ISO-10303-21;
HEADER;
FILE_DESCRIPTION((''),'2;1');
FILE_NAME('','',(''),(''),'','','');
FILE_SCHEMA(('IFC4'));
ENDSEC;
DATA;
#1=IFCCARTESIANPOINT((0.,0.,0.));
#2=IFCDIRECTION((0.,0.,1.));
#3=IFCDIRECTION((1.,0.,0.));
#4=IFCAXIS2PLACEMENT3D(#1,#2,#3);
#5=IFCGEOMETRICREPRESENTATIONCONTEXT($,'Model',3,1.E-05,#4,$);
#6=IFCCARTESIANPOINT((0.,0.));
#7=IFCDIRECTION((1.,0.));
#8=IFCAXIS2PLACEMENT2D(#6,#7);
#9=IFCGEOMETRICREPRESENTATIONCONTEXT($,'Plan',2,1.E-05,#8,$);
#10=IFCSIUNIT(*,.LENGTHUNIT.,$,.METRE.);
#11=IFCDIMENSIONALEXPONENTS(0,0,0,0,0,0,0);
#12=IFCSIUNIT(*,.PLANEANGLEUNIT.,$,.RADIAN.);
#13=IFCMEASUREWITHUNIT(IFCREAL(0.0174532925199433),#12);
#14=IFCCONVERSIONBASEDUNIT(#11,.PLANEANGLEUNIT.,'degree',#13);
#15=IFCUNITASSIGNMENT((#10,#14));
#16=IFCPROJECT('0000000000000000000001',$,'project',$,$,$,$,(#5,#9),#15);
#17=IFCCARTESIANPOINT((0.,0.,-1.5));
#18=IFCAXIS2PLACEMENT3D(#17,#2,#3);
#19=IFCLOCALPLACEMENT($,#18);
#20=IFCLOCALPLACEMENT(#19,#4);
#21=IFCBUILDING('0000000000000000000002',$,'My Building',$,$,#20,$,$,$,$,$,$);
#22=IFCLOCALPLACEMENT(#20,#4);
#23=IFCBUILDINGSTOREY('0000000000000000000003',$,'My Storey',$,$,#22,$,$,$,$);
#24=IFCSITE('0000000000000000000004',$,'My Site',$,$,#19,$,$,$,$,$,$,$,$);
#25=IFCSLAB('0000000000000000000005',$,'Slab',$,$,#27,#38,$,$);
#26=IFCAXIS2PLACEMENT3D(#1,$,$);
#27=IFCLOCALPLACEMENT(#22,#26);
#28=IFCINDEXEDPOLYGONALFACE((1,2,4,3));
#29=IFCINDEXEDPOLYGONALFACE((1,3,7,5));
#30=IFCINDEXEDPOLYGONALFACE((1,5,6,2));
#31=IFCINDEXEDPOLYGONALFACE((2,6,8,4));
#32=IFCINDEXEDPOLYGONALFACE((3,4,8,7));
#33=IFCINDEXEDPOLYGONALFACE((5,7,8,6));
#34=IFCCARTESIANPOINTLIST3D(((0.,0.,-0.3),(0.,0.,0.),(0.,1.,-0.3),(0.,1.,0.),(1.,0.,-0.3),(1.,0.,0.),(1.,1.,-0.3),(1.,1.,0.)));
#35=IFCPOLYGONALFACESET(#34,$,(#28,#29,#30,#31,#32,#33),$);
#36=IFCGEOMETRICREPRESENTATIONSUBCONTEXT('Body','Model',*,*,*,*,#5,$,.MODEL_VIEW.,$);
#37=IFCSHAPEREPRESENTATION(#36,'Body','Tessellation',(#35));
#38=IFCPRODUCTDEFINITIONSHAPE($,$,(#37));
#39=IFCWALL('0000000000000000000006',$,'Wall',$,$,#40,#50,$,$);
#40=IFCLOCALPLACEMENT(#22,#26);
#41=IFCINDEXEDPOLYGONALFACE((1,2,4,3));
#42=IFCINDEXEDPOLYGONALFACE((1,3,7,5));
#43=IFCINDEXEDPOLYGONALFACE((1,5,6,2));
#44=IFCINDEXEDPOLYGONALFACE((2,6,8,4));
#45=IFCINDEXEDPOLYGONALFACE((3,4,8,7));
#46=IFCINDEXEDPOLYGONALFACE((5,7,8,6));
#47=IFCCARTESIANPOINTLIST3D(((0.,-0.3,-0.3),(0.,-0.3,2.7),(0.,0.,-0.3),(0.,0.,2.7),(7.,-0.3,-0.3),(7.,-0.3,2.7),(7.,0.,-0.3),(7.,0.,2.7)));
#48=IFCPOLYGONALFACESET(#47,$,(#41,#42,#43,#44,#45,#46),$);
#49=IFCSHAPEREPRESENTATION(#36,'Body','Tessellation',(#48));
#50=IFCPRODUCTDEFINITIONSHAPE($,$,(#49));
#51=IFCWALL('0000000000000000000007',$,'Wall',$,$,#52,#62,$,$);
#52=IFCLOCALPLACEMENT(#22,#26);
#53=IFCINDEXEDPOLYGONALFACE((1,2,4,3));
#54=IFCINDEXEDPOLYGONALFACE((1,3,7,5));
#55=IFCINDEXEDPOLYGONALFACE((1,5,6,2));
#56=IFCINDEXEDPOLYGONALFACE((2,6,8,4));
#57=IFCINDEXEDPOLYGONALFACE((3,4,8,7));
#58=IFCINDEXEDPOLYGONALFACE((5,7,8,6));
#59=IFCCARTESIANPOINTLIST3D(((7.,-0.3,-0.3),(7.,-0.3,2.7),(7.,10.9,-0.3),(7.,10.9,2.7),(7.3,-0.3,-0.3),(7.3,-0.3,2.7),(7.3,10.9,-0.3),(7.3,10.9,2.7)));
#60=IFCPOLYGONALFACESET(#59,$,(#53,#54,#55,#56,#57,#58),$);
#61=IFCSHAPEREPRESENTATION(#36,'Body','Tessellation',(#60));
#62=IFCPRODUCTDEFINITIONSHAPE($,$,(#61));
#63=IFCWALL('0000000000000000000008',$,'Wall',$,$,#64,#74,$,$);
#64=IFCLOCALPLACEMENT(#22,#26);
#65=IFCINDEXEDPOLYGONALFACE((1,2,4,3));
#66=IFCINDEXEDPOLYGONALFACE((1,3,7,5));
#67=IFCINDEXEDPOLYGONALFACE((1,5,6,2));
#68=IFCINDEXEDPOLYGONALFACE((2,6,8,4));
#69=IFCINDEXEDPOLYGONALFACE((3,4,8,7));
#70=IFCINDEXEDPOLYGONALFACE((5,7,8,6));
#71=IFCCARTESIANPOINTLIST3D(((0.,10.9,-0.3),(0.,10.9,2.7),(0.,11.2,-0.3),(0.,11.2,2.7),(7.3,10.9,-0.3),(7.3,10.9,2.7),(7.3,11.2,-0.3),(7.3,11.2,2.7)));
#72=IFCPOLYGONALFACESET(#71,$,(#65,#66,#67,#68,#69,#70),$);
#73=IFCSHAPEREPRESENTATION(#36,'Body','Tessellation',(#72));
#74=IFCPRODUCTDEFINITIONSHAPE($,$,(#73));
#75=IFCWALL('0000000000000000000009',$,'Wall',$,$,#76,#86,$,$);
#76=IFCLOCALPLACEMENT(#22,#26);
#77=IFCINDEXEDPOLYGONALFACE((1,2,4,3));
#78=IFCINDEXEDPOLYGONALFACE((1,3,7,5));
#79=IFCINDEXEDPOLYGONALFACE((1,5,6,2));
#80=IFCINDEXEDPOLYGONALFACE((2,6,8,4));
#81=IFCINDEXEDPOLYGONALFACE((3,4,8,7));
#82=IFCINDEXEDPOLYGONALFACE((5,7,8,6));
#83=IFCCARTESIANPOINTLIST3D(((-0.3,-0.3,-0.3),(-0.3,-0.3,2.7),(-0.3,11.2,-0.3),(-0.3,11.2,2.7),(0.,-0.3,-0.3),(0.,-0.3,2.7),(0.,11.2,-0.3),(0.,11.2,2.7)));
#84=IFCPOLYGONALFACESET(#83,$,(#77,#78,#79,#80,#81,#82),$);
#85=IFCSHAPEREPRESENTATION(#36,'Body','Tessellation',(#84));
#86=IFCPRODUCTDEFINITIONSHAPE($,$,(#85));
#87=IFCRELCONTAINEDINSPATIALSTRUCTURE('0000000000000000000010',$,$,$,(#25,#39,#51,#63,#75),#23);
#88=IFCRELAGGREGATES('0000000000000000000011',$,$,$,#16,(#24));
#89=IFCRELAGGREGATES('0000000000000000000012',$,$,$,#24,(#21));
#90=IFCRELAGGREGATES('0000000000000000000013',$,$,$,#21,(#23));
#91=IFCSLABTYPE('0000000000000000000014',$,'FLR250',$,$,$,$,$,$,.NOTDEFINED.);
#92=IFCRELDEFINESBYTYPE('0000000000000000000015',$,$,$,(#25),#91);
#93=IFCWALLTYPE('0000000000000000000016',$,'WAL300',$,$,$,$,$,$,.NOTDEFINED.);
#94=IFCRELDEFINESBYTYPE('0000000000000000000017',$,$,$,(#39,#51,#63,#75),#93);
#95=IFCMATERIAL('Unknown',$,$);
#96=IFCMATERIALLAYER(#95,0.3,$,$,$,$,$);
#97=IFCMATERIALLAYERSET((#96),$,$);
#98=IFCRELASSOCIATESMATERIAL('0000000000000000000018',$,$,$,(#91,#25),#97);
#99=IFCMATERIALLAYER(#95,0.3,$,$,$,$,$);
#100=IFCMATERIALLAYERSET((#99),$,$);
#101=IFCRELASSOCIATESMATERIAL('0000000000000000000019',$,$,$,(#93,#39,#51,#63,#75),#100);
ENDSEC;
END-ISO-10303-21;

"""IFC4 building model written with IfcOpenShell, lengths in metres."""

from ifc_helpers import new_model, entity, si_unit, converted_unit, frame, origin_with_axes, origin_2d_with_axis, place, context, subcontext, project, spatial, line, indexed_curve, outline, extrude, material, layer, layer_set, layer_usage, type_object, element, save


model = new_model("IFC4")

# Units and contexts
model_context = context("Model", 3, precision=1e-05, world=origin_with_axes())
plan_context = context("Plan", 2, precision=1e-05, world=origin_2d_with_axis())
body_context = subcontext(model_context, "Body", "Model", "MODEL_VIEW")
ifc_project = project(units=[si_unit("LENGTHUNIT", "METRE"), converted_unit("PLANEANGLEUNIT", "degree", entity("IfcReal", 0.0174532925199433), si_unit("PLANEANGLEUNIT", "RADIAN"), dimensions=[0, 0, 0, 0, 0, 0, 0])], contexts=[model_context, plan_context])

# Site, building, storey
site_placement = place(None, frame((0.0, 0.0, -1.5), z_axis=(0.0, 0.0, 1.0), x_axis=(1.0, 0.0, 0.0)))
site = spatial("IfcSite", under=ifc_project, at=site_placement, Name="My Site")
building_placement = place(site_placement, origin_with_axes())
building = spatial("IfcBuilding", under=site, at=building_placement, Name="My Building")
storey_placement = place(building_placement, origin_with_axes())
storey = spatial("IfcBuildingStorey", under=building, at=storey_placement, Name="My Storey")

# Slab
ifc_material = material(Name="Unknown")
ifc_layer_1 = layer(ifc_material, 0.3)
ifc_layer_set_1 = layer_set([ifc_layer_1])
ifc_layer_usage_1 = layer_usage(ifc_layer_set_1, "AXIS3", "POSITIVE", 0.0)
slab_type = type_object("IfcSlabType", Name="FLR250", PredefinedType="NOTDEFINED", material=ifc_layer_set_1)
slab_placement = place(storey_placement, frame((0.0, 0.0, -0.3), z_axis=(0.0, 0.0, 1.0), x_axis=(1.0, 0.0, 0.0)))
element("IfcSlab", 1, at=slab_placement, inside=storey, type_object=slab_type, material=ifc_layer_usage_1, Name="Slab", context=body_context, shape_type="SweptSolid", body=[
    extrude(outline(indexed_curve([(0.0, 0.0), (0.0, 1.0), (1.0, 1.0), (1.0, 0.0)], segments=[line(4, 1), line(1, 2), line(2, 3), line(3, 4)], self_intersect=False)), None, (0.0, 0.0, 1.0), 0.3),
])

# Walls
ifc_layer_2 = layer(ifc_material, 0.3)
ifc_layer_set_2 = layer_set([ifc_layer_2])
ifc_layer_usage_2 = layer_usage(ifc_layer_set_2, "AXIS2", "POSITIVE", 0.0)
wall_type = type_object("IfcWallType", Name="WAL300", PredefinedType="NOTDEFINED", material=ifc_layer_set_2)
wall_1_placement = place(storey_placement, frame((0.0, -0.3, -0.3), z_axis=(0.0, 0.0, 1.0), x_axis=(1.0, 0.0, 0.0)))
element("IfcWall", 2, at=wall_1_placement, inside=storey, type_object=wall_type, material=ifc_layer_usage_2, Name="Wall", context=body_context, shape_type="SweptSolid", body=[
    extrude(outline(indexed_curve([(0.0, 0.0), (0.0, 0.3), (7.0, 0.3), (7.0, 0.0), (0.0, 0.0)], self_intersect=False)), origin_with_axes(), (0.0, 0.0, 1.0), 3.0),
])
ifc_layer_usage_3 = layer_usage(ifc_layer_set_2, "AXIS2", "POSITIVE", 0.0)
wall_2_placement = place(storey_placement, frame((7.0, 10.9, -0.3), z_axis=(0.0, 0.0, 1.0), x_axis=(0.0, -1.0, 0.0)))
element("IfcWall", 3, at=wall_2_placement, inside=storey, type_object=wall_type, material=ifc_layer_usage_3, Name="Wall", context=body_context, shape_type="SweptSolid", body=[
    extrude(outline(indexed_curve([(0.0, 0.0), (0.0, 0.3), (11.2, 0.3), (11.2, 0.0), (0.0, 0.0)], self_intersect=False)), origin_with_axes(), (0.0, 0.0, 1.0), 3.0),
])
ifc_layer_usage_4 = layer_usage(ifc_layer_set_2, "AXIS2", "POSITIVE", 0.0)
wall_3_placement = place(storey_placement, frame((7.3, 11.2, -0.3), z_axis=(0.0, 0.0, 1.0), x_axis=(-1.0, 0.0, 0.0)))
element("IfcWall", 4, at=wall_3_placement, inside=storey, type_object=wall_type, material=ifc_layer_usage_4, Name="Wall", context=body_context, shape_type="SweptSolid", body=[
    extrude(outline(indexed_curve([(0.0, 0.0), (0.0, 0.3), (7.3, 0.3), (7.3, 0.0), (0.0, 0.0)], self_intersect=False)), origin_with_axes(), (0.0, 0.0, 1.0), 3.0),
])
ifc_layer_usage_5 = layer_usage(ifc_layer_set_2, "AXIS2", "POSITIVE", 0.0)
wall_4_placement = place(storey_placement, frame((-0.3, 11.2, -0.3), z_axis=(0.0, 0.0, 1.0), x_axis=(0.0, -1.0, 0.0)))
element("IfcWall", 5, at=wall_4_placement, inside=storey, type_object=wall_type, material=ifc_layer_usage_5, Name="Wall", context=body_context, shape_type="SweptSolid", body=[
    extrude(outline(indexed_curve([(0.0, 0.0), (0.0, 0.3), (11.5, 0.3), (11.5, 0.0), (0.0, 0.0)], self_intersect=False)), origin_with_axes(), (0.0, 0.0, 1.0), 3.0),
])

save(model, "model.ifc")
